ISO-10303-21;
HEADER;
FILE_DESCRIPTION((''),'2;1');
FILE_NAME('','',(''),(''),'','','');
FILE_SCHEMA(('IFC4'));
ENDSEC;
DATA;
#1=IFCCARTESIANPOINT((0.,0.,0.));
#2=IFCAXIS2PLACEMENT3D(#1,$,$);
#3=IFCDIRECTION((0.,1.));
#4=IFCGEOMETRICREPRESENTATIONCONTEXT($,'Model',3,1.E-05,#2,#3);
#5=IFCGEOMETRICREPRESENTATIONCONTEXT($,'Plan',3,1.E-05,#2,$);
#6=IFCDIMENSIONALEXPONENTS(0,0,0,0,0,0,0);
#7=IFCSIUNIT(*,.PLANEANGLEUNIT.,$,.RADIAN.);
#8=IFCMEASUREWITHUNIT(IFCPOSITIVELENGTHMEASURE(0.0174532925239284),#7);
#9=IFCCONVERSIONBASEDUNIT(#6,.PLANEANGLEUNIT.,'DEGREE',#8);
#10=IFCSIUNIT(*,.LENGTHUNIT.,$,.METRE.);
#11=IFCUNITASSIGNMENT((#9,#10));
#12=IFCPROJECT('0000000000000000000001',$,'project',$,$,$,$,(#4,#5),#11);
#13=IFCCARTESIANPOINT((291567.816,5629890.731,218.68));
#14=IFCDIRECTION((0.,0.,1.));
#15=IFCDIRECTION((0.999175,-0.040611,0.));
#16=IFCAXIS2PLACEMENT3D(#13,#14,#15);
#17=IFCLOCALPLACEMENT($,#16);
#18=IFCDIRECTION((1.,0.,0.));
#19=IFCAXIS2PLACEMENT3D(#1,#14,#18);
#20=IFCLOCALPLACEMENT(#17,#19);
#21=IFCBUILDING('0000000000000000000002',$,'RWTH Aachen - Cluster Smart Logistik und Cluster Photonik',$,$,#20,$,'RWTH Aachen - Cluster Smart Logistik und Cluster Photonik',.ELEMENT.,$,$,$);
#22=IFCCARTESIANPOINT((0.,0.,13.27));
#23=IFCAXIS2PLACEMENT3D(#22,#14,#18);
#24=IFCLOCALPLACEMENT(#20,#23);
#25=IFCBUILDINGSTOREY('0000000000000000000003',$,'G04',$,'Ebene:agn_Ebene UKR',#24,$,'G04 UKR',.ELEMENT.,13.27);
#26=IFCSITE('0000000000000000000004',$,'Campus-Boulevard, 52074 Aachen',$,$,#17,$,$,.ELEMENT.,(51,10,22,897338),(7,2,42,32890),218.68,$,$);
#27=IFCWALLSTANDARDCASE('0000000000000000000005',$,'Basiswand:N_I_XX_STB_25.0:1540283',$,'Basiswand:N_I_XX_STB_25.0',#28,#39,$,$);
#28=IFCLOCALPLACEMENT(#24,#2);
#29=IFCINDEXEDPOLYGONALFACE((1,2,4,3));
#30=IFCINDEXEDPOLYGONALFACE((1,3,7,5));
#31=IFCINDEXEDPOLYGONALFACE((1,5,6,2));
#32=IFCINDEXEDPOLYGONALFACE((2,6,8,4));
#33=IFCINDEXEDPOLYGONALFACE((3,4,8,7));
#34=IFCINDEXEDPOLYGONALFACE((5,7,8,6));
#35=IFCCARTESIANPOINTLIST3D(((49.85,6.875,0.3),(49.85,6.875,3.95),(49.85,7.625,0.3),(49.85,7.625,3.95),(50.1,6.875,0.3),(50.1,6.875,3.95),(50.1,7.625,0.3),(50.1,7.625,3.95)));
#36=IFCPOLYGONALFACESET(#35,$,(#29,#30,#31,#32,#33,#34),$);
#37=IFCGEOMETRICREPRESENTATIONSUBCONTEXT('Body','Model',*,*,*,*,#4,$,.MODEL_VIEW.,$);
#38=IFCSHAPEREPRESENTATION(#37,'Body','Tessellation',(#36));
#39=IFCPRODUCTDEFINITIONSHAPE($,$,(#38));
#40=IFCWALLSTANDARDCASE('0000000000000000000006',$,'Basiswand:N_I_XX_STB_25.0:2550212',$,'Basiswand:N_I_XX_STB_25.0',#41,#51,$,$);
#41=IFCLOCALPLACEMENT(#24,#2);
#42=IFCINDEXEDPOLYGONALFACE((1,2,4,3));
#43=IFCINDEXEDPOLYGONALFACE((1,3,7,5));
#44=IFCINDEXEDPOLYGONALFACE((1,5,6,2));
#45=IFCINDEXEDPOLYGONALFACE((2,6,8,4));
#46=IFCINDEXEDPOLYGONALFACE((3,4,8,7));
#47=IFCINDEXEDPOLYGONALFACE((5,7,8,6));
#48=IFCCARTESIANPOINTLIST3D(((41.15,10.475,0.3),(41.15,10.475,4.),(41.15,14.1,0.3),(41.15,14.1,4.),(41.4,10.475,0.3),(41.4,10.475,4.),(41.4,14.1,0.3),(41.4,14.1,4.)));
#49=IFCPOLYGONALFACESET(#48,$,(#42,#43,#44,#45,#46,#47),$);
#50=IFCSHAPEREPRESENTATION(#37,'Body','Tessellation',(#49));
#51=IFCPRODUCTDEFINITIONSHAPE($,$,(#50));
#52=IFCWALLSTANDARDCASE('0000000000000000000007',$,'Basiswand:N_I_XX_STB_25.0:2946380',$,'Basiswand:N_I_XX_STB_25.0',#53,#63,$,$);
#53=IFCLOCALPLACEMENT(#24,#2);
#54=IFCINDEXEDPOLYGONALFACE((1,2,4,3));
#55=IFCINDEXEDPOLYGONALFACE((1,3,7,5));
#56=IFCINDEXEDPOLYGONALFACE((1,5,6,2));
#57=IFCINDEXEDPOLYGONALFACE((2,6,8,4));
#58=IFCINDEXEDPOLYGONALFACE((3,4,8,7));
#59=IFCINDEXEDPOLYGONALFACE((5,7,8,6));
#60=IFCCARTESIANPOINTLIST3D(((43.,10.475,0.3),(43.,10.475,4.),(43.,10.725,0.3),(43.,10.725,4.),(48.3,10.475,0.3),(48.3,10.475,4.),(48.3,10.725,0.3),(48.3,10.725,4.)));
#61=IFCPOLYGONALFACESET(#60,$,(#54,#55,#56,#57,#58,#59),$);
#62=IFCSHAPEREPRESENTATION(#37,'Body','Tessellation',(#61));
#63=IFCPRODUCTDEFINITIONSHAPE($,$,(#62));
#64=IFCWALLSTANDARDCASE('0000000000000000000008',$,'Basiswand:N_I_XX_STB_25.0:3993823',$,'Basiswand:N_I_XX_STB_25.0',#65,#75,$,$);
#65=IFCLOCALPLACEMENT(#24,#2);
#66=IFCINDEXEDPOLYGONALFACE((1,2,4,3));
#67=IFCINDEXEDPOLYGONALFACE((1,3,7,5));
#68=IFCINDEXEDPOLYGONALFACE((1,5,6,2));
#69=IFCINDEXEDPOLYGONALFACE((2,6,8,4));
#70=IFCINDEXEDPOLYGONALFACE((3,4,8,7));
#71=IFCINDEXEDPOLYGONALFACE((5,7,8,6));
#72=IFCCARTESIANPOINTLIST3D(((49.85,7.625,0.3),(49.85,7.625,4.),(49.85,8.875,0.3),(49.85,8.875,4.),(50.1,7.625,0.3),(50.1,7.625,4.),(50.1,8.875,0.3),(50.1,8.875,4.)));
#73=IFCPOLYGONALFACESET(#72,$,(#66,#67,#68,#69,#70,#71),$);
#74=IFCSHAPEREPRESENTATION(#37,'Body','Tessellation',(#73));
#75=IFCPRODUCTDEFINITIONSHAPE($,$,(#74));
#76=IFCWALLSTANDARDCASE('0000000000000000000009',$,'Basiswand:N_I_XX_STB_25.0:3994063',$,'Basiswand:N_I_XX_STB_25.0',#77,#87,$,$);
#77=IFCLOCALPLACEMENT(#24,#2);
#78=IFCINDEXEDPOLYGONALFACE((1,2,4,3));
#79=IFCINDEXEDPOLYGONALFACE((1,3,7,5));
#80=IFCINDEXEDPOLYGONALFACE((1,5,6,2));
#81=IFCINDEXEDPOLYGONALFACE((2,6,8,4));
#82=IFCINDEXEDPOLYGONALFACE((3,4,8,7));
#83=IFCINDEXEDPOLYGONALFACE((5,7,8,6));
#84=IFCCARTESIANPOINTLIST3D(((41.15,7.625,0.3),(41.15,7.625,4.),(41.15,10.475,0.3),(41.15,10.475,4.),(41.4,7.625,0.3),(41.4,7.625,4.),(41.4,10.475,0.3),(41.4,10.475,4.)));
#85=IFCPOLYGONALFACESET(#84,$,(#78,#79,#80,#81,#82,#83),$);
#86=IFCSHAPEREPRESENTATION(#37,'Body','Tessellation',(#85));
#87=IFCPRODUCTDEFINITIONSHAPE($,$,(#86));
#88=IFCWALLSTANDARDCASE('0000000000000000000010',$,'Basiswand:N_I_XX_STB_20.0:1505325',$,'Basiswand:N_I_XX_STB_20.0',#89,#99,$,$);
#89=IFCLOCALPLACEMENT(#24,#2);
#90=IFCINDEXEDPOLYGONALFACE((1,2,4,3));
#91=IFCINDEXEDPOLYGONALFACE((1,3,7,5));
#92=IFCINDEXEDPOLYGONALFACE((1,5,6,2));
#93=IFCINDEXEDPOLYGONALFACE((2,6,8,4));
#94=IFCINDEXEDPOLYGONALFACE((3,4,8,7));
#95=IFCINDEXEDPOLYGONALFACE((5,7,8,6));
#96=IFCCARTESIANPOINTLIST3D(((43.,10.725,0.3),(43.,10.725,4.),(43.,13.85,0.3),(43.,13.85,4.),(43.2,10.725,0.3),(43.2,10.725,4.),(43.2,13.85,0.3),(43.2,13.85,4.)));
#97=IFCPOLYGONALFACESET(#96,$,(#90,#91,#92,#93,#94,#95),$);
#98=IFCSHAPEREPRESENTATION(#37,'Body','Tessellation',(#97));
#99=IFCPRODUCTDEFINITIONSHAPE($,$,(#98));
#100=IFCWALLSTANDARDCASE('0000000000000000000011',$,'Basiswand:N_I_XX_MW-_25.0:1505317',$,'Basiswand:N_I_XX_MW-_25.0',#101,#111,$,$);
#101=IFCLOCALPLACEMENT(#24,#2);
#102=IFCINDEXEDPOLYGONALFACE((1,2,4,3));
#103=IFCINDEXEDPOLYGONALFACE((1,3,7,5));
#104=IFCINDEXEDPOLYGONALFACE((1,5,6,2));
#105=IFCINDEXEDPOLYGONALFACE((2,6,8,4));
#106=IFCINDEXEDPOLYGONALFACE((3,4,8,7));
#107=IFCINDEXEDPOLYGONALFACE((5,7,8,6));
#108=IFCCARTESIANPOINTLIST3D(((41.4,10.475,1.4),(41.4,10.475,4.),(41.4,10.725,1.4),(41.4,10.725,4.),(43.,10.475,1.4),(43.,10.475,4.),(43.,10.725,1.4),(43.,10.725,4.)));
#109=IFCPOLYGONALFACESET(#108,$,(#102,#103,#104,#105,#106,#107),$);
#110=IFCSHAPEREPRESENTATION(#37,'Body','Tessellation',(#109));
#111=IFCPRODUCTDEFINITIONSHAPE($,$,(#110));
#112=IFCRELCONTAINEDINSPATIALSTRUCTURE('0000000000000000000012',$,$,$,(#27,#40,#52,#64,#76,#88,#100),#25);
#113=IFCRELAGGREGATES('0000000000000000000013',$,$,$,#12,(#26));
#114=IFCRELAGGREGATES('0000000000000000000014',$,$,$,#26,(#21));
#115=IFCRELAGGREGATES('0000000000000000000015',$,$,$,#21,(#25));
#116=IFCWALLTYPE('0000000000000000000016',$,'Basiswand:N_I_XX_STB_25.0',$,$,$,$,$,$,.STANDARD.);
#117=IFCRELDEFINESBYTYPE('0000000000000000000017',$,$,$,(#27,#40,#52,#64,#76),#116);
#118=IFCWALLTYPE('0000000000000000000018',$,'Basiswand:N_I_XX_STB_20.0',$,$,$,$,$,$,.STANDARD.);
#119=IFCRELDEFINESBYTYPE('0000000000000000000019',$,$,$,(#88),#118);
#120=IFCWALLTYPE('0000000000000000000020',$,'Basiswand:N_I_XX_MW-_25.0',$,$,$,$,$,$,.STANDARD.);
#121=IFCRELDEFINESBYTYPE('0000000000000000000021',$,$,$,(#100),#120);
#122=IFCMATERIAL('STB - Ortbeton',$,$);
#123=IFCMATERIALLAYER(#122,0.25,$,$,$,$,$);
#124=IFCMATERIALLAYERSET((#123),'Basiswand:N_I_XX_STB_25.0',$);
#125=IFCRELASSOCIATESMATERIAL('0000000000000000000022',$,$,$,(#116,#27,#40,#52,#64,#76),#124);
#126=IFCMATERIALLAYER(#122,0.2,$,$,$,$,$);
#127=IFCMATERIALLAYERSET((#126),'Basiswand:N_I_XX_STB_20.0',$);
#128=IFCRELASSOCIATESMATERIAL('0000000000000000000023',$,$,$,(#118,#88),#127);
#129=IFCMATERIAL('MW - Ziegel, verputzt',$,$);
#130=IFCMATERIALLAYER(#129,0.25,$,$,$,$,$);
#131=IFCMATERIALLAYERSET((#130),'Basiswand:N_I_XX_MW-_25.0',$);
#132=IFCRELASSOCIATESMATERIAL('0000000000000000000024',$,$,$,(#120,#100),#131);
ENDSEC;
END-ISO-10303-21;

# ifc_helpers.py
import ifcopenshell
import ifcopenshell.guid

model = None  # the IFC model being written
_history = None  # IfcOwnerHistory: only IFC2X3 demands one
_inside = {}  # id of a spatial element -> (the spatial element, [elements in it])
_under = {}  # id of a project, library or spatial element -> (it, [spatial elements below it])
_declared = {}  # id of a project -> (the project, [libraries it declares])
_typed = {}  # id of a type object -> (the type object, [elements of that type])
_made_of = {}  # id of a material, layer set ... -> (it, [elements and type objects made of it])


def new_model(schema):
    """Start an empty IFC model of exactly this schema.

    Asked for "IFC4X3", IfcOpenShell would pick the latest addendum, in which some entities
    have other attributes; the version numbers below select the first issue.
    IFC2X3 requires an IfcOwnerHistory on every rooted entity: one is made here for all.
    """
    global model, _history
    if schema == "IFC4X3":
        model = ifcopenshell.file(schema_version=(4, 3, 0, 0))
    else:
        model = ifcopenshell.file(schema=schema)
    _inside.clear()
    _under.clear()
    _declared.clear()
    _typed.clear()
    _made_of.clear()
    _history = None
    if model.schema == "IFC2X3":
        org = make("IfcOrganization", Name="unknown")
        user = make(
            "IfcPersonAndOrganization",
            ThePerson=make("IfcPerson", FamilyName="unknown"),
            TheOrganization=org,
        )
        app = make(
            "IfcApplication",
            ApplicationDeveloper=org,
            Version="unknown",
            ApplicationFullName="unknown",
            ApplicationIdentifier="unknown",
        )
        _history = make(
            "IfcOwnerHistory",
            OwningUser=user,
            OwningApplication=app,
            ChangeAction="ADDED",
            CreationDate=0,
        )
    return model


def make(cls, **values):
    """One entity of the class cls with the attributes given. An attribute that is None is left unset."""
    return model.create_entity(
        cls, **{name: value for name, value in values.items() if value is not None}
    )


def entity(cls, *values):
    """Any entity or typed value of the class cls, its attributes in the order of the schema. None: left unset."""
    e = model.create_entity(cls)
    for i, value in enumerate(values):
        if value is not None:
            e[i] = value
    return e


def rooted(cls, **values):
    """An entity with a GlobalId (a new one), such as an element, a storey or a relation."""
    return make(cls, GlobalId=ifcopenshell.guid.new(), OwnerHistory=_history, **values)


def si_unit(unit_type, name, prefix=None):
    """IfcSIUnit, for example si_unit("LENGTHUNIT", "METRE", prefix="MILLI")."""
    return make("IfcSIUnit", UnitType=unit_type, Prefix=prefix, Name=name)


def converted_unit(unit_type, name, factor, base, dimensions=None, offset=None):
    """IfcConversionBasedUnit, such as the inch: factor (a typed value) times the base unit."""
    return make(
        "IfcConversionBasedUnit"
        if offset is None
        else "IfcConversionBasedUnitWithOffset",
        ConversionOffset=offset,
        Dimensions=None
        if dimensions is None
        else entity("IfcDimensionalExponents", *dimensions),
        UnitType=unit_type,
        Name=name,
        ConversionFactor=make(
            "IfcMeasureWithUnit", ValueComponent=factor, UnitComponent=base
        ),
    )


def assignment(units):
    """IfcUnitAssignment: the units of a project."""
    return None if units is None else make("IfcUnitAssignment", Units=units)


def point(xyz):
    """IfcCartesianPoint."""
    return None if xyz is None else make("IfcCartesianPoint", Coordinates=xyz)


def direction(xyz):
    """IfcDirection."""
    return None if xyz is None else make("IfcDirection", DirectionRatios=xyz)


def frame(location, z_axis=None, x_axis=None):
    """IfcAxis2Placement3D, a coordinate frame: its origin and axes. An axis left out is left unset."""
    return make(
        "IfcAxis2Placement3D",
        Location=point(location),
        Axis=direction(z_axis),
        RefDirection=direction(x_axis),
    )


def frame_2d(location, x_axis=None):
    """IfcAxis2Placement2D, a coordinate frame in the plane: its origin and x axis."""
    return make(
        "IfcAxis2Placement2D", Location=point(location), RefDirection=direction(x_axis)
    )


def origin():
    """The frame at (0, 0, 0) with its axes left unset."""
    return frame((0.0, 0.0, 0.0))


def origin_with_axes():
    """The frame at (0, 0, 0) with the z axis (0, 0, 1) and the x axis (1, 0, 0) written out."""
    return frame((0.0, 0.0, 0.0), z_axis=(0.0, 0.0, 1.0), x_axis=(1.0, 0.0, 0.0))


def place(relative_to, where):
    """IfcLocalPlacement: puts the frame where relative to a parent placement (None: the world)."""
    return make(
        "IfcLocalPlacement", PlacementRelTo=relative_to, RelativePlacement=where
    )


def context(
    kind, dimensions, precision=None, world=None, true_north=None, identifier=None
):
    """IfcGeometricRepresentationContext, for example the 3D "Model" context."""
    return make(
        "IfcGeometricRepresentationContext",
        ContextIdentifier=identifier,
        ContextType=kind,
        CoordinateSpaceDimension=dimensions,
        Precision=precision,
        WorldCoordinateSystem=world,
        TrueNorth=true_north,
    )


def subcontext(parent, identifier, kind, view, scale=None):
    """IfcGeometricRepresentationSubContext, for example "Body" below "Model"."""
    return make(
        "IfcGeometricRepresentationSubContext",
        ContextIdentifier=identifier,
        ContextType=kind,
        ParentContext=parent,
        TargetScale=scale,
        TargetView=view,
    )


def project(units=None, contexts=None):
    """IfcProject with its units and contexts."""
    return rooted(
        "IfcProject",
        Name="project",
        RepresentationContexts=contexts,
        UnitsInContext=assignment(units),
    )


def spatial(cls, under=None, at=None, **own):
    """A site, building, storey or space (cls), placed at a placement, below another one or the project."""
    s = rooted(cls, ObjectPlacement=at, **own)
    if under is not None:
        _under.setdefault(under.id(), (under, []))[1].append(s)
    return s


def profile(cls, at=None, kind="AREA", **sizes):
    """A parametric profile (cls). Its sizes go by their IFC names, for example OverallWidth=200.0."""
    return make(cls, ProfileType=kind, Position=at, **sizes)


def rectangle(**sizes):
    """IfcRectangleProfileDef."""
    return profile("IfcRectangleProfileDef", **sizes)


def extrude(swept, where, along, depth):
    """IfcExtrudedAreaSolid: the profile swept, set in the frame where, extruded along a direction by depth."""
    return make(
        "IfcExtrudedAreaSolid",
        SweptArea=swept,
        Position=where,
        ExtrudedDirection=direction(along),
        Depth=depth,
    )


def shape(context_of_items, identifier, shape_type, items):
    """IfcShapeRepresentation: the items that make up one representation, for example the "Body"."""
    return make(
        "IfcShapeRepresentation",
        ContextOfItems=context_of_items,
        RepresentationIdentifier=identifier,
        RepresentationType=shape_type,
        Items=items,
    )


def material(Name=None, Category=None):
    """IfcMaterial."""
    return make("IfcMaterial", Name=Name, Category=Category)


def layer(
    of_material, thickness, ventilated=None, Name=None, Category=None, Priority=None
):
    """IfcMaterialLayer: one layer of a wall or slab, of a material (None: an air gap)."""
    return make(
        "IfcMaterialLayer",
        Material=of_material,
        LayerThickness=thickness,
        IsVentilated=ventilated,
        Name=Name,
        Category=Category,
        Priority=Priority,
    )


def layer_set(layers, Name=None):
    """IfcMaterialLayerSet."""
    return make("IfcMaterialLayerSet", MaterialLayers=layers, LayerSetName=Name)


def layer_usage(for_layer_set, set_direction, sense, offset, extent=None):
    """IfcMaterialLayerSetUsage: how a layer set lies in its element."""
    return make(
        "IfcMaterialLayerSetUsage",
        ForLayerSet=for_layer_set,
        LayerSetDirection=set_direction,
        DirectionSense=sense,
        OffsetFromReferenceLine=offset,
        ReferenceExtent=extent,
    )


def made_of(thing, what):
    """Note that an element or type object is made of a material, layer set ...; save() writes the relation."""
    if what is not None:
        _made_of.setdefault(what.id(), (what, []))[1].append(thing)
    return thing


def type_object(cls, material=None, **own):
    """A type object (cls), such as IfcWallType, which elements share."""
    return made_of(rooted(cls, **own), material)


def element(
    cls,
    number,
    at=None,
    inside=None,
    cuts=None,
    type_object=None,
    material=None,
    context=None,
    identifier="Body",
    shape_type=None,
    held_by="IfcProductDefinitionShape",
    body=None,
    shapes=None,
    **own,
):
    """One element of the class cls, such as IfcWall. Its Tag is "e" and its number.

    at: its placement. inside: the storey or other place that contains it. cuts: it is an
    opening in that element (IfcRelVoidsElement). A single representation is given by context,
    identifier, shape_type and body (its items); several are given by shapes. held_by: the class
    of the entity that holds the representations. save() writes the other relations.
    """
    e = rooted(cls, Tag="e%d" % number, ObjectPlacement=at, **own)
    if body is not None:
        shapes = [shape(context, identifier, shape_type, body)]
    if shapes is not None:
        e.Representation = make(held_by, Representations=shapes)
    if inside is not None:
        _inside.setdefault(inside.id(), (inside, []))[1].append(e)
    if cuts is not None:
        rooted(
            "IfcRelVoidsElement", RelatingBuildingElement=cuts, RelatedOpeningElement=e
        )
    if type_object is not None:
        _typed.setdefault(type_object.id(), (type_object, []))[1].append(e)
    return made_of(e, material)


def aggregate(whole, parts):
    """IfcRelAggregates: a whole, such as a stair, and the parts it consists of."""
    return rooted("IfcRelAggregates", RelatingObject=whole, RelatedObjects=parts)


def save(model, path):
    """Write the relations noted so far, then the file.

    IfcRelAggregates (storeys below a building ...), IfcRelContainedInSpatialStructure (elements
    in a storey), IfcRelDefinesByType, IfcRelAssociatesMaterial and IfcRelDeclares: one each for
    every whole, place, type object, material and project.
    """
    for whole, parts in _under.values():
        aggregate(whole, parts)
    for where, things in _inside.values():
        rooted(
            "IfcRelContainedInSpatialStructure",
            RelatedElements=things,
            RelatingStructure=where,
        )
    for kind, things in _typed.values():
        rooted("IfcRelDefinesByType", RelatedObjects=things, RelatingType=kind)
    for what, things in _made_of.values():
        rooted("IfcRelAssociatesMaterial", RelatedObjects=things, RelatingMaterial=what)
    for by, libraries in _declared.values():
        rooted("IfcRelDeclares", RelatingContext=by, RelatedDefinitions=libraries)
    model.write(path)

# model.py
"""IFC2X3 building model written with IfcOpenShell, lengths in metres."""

from ifc_helpers import new_model, entity, si_unit, converted_unit, direction, frame, frame_2d, origin, origin_with_axes, place, context, subcontext, project, spatial, rectangle, extrude, material, layer, layer_set, layer_usage, type_object, element, save


model = new_model("IFC2X3")

# Units and contexts
model_context = context("Model", 3, precision=1e-05, world=origin(), true_north=direction((0.0, 1.0)))
plan_context = context("Plan", 3, precision=1e-05, world=origin())
body_context = subcontext(model_context, "Body", "Model", "MODEL_VIEW")
ifc_project = project(units=[converted_unit("PLANEANGLEUNIT", "DEGREE", entity("IfcPositiveLengthMeasure", 0.0174532925239284), si_unit("PLANEANGLEUNIT", "RADIAN"), dimensions=[0, 0, 0, 0, 0, 0, 0]), si_unit("LENGTHUNIT", "METRE")], contexts=[model_context, plan_context])

# Site, building, storey
site_placement = place(None, frame((291567.816, 5629890.731, 218.68), z_axis=(0.0, 0.0, 1.0), x_axis=(0.999175, -0.040611, 0.0)))
site = spatial("IfcSite", under=ifc_project, at=site_placement, Name="Campus-Boulevard, 52074 Aachen", CompositionType="ELEMENT", RefLatitude=(51, 10, 22, 897338), RefLongitude=(7, 2, 42, 32890), RefElevation=218.68)
building_placement = place(site_placement, origin_with_axes())
building = spatial("IfcBuilding", under=site, at=building_placement, Name="RWTH Aachen - Cluster Smart Logistik und Cluster Photonik", LongName="RWTH Aachen - Cluster Smart Logistik und Cluster Photonik", CompositionType="ELEMENT")
storey_placement = place(building_placement, frame((0.0, 0.0, 13.27), z_axis=(0.0, 0.0, 1.0), x_axis=(1.0, 0.0, 0.0)))
storey = spatial("IfcBuildingStorey", under=building, at=storey_placement, Name="G04", ObjectType="Ebene:agn_Ebene UKR", LongName="G04 UKR", CompositionType="ELEMENT", Elevation=13.27)

# Shared definitions
ifc_material_1 = material(Name="STB - Ortbeton")

# Shared definitions
ifc_layer_1 = layer(ifc_material_1, 0.25)
ifc_layer_set_1 = layer_set([ifc_layer_1], Name="Basiswand:N_I_XX_STB_25.0")
wall_type_1 = type_object("IfcWallType", Name="Basiswand:N_I_XX_STB_25.0", PredefinedType="STANDARD", material=ifc_layer_set_1)

# Walls
ifc_layer_usage_1 = layer_usage(ifc_layer_set_1, "AXIS2", "POSITIVE", -0.125)
wall_1_placement = place(storey_placement, frame((49.975, 6.875, 0.3), z_axis=(0.0, 0.0, 1.0), x_axis=(0.0, 1.0, 0.0)))
element("IfcWallStandardCase", 1, at=wall_1_placement, inside=storey, type_object=wall_type_1, material=ifc_layer_usage_1, Name="Basiswand:N_I_XX_STB_25.0:1540283", ObjectType="Basiswand:N_I_XX_STB_25.0", context=body_context, shape_type="SweptSolid", body=[
    extrude(rectangle(XDim=0.75, YDim=0.25, at=frame_2d((0.375, 0.0), x_axis=(-1.0, 0.0))), origin(), (0.0, 0.0, 1.0), 3.65),
])
ifc_layer_usage_2 = layer_usage(ifc_layer_set_1, "AXIS2", "NEGATIVE", 0.125)
wall_2_placement = place(storey_placement, frame((41.275, 10.475, 0.3), z_axis=(0.0, 0.0, 1.0), x_axis=(0.0, 1.0, 0.0)))
element("IfcWallStandardCase", 2, at=wall_2_placement, inside=storey, type_object=wall_type_1, material=ifc_layer_usage_2, Name="Basiswand:N_I_XX_STB_25.0:2550212", ObjectType="Basiswand:N_I_XX_STB_25.0", context=body_context, shape_type="SweptSolid", body=[
    extrude(rectangle(XDim=3.625, YDim=0.25, at=frame_2d((1.8125, 0.0), x_axis=(-1.0, 0.0))), origin(), (0.0, 0.0, 1.0), 3.7),
])
ifc_layer_usage_3 = layer_usage(ifc_layer_set_1, "AXIS2", "NEGATIVE", 0.125)
wall_3_placement = place(storey_placement, frame((43.0, 10.6, 0.3), z_axis=(0.0, 0.0, 1.0), x_axis=(1.0, 0.0, 0.0)))
element("IfcWallStandardCase", 3, at=wall_3_placement, inside=storey, type_object=wall_type_1, material=ifc_layer_usage_3, Name="Basiswand:N_I_XX_STB_25.0:2946380", ObjectType="Basiswand:N_I_XX_STB_25.0", context=body_context, shape_type="SweptSolid", body=[
    extrude(rectangle(XDim=5.3, YDim=0.25, at=frame_2d((2.65, 0.0), x_axis=(-1.0, 0.0))), origin(), (0.0, 0.0, 1.0), 3.7),
])
ifc_layer_usage_4 = layer_usage(ifc_layer_set_1, "AXIS2", "POSITIVE", -0.125)
wall_4_placement = place(storey_placement, frame((49.975, 7.625, 0.3), z_axis=(0.0, 0.0, 1.0), x_axis=(0.0, 1.0, 0.0)))
element("IfcWallStandardCase", 4, at=wall_4_placement, inside=storey, type_object=wall_type_1, material=ifc_layer_usage_4, Name="Basiswand:N_I_XX_STB_25.0:3993823", ObjectType="Basiswand:N_I_XX_STB_25.0", context=body_context, shape_type="SweptSolid", body=[
    extrude(rectangle(XDim=1.25, YDim=0.25, at=frame_2d((0.625, 0.0), x_axis=(-1.0, 0.0))), origin(), (0.0, 0.0, 1.0), 3.7),
])
ifc_layer_usage_5 = layer_usage(ifc_layer_set_1, "AXIS2", "NEGATIVE", 0.125)
wall_5_placement = place(storey_placement, frame((41.275, 7.625, 0.3), z_axis=(0.0, 0.0, 1.0), x_axis=(0.0, 1.0, 0.0)))
element("IfcWallStandardCase", 5, at=wall_5_placement, inside=storey, type_object=wall_type_1, material=ifc_layer_usage_5, Name="Basiswand:N_I_XX_STB_25.0:3994063", ObjectType="Basiswand:N_I_XX_STB_25.0", context=body_context, shape_type="SweptSolid", body=[
    extrude(rectangle(XDim=2.85, YDim=0.25, at=frame_2d((1.425, 0.0), x_axis=(-1.0, 0.0))), origin(), (0.0, 0.0, 1.0), 3.7),
])
ifc_layer_2 = layer(ifc_material_1, 0.2)
ifc_layer_set_2 = layer_set([ifc_layer_2], Name="Basiswand:N_I_XX_STB_20.0")
ifc_layer_usage_6 = layer_usage(ifc_layer_set_2, "AXIS2", "NEGATIVE", 0.1)
wall_type_2 = type_object("IfcWallType", Name="Basiswand:N_I_XX_STB_20.0", PredefinedType="STANDARD", material=ifc_layer_set_2)
wall_6_placement = place(storey_placement, frame((43.1, 13.85, 0.3), z_axis=(0.0, 0.0, 1.0), x_axis=(0.0, -1.0, 0.0)))
element("IfcWallStandardCase", 6, at=wall_6_placement, inside=storey, type_object=wall_type_2, material=ifc_layer_usage_6, Name="Basiswand:N_I_XX_STB_20.0:1505325", ObjectType="Basiswand:N_I_XX_STB_20.0", context=body_context, shape_type="SweptSolid", body=[
    extrude(rectangle(XDim=3.125, YDim=0.2, at=frame_2d((1.5625, 0.0), x_axis=(-1.0, 0.0))), origin(), (0.0, 0.0, 1.0), 3.7),
])
ifc_material_2 = material(Name="MW - Ziegel, verputzt")
ifc_layer_3 = layer(ifc_material_2, 0.25)
ifc_layer_set_3 = layer_set([ifc_layer_3], Name="Basiswand:N_I_XX_MW-_25.0")
ifc_layer_usage_7 = layer_usage(ifc_layer_set_3, "AXIS2", "NEGATIVE", 0.125)
wall_type_3 = type_object("IfcWallType", Name="Basiswand:N_I_XX_MW-_25.0", PredefinedType="STANDARD", material=ifc_layer_set_3)
wall_7_placement = place(storey_placement, frame((41.4, 10.6, 1.4), z_axis=(0.0, 0.0, 1.0), x_axis=(1.0, 0.0, 0.0)))
element("IfcWallStandardCase", 7, at=wall_7_placement, inside=storey, type_object=wall_type_3, material=ifc_layer_usage_7, Name="Basiswand:N_I_XX_MW-_25.0:1505317", ObjectType="Basiswand:N_I_XX_MW-_25.0", context=body_context, shape_type="SweptSolid", body=[
    extrude(rectangle(XDim=1.6, YDim=0.25, at=frame_2d((0.8, 0.0), x_axis=(-1.0, 0.0))), origin(), (0.0, 0.0, 1.0), 2.6),
])

save(model, "model.ifc")
